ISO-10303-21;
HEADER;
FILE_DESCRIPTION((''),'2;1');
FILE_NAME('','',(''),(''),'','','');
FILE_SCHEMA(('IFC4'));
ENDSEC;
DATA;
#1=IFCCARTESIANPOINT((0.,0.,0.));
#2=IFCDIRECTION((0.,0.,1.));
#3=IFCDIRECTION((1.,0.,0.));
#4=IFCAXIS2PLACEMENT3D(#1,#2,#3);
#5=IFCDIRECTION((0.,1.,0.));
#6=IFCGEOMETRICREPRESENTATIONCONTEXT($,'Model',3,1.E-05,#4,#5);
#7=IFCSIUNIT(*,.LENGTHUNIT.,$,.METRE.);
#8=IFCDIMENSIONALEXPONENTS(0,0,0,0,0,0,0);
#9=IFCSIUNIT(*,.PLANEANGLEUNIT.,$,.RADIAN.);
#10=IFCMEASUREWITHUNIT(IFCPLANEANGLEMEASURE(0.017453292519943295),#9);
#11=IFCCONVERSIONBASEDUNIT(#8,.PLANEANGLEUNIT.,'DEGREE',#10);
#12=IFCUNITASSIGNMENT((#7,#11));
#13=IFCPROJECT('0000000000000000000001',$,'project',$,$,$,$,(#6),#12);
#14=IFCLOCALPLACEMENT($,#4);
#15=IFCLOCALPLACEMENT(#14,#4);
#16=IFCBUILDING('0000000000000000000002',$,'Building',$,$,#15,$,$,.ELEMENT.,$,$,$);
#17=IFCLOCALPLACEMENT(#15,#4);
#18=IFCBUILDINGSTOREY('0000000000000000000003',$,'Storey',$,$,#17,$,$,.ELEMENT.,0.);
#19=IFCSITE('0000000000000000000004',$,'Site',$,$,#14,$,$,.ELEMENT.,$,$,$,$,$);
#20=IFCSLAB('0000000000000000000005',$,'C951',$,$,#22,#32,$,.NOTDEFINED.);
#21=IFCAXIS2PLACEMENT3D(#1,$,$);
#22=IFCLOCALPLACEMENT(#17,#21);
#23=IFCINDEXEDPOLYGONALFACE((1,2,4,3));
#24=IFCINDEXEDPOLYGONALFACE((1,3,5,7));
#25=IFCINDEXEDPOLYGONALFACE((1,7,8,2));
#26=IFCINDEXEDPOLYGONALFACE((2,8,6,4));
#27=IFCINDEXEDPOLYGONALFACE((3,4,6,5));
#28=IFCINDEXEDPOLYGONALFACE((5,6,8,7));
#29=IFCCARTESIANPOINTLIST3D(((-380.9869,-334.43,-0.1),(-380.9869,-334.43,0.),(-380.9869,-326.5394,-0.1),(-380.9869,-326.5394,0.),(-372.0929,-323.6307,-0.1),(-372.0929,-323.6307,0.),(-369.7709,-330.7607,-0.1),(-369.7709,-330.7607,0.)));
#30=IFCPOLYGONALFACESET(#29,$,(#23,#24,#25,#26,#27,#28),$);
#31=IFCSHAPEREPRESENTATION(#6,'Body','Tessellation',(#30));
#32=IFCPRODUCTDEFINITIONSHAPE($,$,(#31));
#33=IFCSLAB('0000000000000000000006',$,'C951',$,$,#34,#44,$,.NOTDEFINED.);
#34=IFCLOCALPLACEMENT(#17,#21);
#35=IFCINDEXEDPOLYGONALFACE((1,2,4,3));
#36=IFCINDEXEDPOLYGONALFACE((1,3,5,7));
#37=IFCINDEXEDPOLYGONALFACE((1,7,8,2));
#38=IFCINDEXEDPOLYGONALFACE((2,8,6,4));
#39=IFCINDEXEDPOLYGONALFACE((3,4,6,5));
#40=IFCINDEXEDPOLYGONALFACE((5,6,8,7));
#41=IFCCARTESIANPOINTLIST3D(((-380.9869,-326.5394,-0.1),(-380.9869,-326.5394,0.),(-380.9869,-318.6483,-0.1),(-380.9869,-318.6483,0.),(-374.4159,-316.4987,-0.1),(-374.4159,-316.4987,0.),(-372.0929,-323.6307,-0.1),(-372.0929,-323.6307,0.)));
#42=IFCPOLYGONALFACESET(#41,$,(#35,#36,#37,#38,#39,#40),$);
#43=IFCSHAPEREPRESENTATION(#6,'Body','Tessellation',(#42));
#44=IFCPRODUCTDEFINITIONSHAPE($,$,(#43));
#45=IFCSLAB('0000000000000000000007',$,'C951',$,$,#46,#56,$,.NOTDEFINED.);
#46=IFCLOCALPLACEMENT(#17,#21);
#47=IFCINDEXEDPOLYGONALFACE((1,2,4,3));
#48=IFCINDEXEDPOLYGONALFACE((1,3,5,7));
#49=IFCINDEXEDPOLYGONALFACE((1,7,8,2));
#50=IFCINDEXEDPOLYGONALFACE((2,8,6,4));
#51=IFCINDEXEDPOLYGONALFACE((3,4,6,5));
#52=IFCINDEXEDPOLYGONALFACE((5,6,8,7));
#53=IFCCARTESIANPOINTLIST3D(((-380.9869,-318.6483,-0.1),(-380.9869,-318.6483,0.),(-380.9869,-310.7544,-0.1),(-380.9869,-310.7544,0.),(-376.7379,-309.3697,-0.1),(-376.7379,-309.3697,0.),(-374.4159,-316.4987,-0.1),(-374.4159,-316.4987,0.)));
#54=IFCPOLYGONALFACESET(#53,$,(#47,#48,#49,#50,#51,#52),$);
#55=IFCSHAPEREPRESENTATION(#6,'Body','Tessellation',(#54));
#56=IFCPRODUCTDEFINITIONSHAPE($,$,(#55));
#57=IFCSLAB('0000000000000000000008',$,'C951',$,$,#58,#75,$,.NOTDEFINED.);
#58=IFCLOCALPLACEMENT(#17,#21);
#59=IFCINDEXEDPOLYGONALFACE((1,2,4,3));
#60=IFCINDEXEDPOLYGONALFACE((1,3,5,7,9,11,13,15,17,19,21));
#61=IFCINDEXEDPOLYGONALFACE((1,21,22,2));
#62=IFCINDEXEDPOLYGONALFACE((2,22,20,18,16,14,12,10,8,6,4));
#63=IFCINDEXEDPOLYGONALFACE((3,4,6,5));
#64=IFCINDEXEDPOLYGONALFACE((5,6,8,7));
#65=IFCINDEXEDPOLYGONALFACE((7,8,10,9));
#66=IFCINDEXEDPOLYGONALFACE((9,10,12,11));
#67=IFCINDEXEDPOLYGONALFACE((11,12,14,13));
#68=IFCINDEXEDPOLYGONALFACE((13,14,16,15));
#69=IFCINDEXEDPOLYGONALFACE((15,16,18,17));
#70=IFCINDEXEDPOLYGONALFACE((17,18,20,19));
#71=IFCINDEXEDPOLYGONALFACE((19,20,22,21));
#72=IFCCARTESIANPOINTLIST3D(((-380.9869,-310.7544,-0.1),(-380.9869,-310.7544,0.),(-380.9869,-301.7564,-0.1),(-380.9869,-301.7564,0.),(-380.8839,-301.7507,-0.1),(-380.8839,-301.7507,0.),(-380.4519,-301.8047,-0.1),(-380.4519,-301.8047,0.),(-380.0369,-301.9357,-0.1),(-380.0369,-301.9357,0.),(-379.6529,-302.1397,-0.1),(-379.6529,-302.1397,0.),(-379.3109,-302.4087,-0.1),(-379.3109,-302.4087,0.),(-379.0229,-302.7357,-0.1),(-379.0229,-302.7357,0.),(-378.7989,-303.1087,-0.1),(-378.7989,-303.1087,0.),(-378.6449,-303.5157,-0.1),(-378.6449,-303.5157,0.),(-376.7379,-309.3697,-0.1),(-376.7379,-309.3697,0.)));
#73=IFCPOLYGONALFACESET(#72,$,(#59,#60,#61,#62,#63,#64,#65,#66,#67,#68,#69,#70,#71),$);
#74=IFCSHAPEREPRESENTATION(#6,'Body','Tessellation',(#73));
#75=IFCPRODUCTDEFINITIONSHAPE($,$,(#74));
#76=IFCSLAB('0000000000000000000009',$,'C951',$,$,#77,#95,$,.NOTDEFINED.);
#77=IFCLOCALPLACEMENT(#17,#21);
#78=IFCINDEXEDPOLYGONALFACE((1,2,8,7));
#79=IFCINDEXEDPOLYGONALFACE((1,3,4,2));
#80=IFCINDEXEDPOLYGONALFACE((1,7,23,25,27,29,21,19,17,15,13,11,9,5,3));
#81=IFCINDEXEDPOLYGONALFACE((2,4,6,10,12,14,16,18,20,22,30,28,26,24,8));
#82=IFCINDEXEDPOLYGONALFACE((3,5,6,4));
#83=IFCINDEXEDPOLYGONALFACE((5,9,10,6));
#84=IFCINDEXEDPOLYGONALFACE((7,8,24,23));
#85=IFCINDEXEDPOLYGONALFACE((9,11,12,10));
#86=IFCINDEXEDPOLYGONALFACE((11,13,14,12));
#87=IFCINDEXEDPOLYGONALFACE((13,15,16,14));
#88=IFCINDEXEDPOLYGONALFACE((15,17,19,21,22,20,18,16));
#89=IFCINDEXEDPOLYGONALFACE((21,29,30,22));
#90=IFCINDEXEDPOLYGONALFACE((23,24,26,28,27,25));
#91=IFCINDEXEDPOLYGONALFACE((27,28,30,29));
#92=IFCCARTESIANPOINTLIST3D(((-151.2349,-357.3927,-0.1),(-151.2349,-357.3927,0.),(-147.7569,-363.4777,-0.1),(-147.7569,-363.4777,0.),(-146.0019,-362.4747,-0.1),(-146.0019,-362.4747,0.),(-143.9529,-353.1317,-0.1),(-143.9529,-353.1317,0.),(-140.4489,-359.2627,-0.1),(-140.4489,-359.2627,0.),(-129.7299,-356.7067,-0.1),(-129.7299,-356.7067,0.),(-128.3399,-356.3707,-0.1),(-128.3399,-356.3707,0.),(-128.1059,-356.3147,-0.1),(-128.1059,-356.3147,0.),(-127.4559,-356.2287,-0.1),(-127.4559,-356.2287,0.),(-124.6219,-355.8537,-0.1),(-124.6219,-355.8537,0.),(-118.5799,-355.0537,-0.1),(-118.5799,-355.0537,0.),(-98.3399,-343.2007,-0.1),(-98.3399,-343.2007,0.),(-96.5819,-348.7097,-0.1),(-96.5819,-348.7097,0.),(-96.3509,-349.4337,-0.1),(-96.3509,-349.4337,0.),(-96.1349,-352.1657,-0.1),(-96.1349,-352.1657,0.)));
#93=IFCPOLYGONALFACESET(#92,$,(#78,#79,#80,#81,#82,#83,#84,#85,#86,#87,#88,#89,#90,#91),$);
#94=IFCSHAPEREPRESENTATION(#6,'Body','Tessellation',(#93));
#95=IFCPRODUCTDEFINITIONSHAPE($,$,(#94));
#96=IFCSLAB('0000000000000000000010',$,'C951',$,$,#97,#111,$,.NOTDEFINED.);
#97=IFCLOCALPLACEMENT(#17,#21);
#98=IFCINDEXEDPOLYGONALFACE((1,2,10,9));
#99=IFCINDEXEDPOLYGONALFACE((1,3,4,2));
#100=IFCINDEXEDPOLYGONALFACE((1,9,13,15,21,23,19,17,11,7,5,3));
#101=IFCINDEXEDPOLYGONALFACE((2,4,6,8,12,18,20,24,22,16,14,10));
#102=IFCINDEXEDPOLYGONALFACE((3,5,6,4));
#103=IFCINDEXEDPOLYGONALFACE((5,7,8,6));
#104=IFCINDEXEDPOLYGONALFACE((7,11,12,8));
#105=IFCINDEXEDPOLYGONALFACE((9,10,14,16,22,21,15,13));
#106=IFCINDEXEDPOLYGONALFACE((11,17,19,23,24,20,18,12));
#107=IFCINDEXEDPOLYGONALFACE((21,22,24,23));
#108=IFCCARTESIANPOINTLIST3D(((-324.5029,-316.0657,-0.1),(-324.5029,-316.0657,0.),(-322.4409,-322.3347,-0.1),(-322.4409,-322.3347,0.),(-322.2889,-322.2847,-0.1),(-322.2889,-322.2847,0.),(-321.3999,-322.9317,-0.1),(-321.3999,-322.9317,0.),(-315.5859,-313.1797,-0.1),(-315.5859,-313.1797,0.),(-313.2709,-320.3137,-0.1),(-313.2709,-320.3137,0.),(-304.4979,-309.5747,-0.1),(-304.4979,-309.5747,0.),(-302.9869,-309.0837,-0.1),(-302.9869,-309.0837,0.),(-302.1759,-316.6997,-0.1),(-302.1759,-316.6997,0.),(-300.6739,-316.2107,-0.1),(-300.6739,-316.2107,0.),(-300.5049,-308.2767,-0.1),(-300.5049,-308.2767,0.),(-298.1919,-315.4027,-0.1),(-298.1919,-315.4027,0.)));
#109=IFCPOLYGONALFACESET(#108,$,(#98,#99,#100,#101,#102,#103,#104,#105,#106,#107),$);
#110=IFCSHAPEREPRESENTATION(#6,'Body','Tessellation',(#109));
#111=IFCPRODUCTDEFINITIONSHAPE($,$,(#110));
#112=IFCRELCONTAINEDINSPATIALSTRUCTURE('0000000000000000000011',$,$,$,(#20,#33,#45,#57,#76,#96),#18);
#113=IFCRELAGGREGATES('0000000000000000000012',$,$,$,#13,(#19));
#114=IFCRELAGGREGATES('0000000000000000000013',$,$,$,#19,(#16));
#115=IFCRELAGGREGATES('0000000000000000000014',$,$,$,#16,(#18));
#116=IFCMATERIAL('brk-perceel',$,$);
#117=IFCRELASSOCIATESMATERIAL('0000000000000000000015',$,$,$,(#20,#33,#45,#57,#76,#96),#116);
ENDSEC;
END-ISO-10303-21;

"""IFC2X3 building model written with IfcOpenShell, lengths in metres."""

from ifc_helpers import new_model, entity, si_unit, converted_unit, direction, frame, origin_with_axes, place, context, project, spatial, polyline, outline, extrude, material, element, save


model = new_model("IFC2X3")

# Units and contexts
model_context = context("Model", 3, precision=1e-05, world=origin_with_axes(), true_north=direction((0.0, 1.0, 0.0)))
ifc_project = project(units=[si_unit("LENGTHUNIT", "METRE"), converted_unit("PLANEANGLEUNIT", "DEGREE", entity("IfcPlaneAngleMeasure", 0.017453292519943295), si_unit("PLANEANGLEUNIT", "RADIAN"), dimensions=[0, 0, 0, 0, 0, 0, 0])], contexts=[model_context])

# Site, building, storey
site_placement = place(None, origin_with_axes())
site = spatial("IfcSite", under=ifc_project, at=site_placement, Name="Site", CompositionType="ELEMENT")
building_placement = place(site_placement, origin_with_axes())
building = spatial("IfcBuilding", under=site, at=building_placement, Name="Building", CompositionType="ELEMENT")
storey_placement = place(building_placement, origin_with_axes())
storey = spatial("IfcBuildingStorey", under=building, at=storey_placement, Name="Storey", CompositionType="ELEMENT", Elevation=0.0)

# Slabs
ifc_material = material(Name="brk-perceel")
slab_1_placement = place(storey_placement, frame((0.0, 0.0, -0.1), z_axis=(0.0, 0.0, 1.0), x_axis=(1.0, 0.0, 0.0)))
element("IfcSlab", 1, at=slab_1_placement, inside=storey, material=ifc_material, Name="C951", PredefinedType="NOTDEFINED", context=model_context, shape_type="SweptSolid", body=[
    extrude(outline(polyline([(-372.0929, -323.6307), (-369.7709, -330.7607), (-380.9869, -334.43), (-380.9869, -326.5394), (-372.0929, -323.6307)])), origin_with_axes(), (0.0, 0.0, 1.0), 0.1),
])
slab_2_placement = place(storey_placement, frame((0.0, 0.0, -0.1), z_axis=(0.0, 0.0, 1.0), x_axis=(1.0, 0.0, 0.0)))
element("IfcSlab", 2, at=slab_2_placement, inside=storey, material=ifc_material, Name="C951", PredefinedType="NOTDEFINED", context=model_context, shape_type="SweptSolid", body=[
    extrude(outline(polyline([(-374.4159, -316.4987), (-372.0929, -323.6307), (-380.9869, -326.5394), (-380.9869, -318.6483), (-374.4159, -316.4987)])), origin_with_axes(), (0.0, 0.0, 1.0), 0.1),
])
slab_3_placement = place(storey_placement, frame((0.0, 0.0, -0.1), z_axis=(0.0, 0.0, 1.0), x_axis=(1.0, 0.0, 0.0)))
element("IfcSlab", 3, at=slab_3_placement, inside=storey, material=ifc_material, Name="C951", PredefinedType="NOTDEFINED", context=model_context, shape_type="SweptSolid", body=[
    extrude(outline(polyline([(-376.7379, -309.3697), (-374.4159, -316.4987), (-380.9869, -318.6483), (-380.9869, -310.7544), (-376.7379, -309.3697)])), origin_with_axes(), (0.0, 0.0, 1.0), 0.1),
])
slab_4_placement = place(storey_placement, frame((0.0, 0.0, -0.1), z_axis=(0.0, 0.0, 1.0), x_axis=(1.0, 0.0, 0.0)))
element("IfcSlab", 4, at=slab_4_placement, inside=storey, material=ifc_material, Name="C951", PredefinedType="NOTDEFINED", context=model_context, shape_type="SweptSolid", body=[
    extrude(outline(polyline([(-380.8839, -301.7507), (-380.4519, -301.8047), (-380.0369, -301.9357), (-379.6529, -302.1397), (-379.3109, -302.4087), (-379.0229, -302.7357), (-378.7989, -303.1087), (-378.6449, -303.5157), (-376.7379, -309.3697), (-380.9869, -310.7544), (-380.9869, -301.7564), (-380.8839, -301.7507)])), origin_with_axes(), (0.0, 0.0, 1.0), 0.1),
])
slab_5_placement = place(storey_placement, frame((0.0, 0.0, -0.1), z_axis=(0.0, 0.0, 1.0), x_axis=(1.0, 0.0, 0.0)))
element("IfcSlab", 5, at=slab_5_placement, inside=storey, material=ifc_material, Name="C951", PredefinedType="NOTDEFINED", context=model_context, shape_type="SweptSolid", body=[
    extrude(outline(polyline([(-127.4559, -356.2287), (-128.1059, -356.3147), (-128.3399, -356.3707), (-129.7299, -356.7067), (-140.4489, -359.2627), (-146.0019, -362.4747), (-147.7569, -363.4777), (-151.2349, -357.3927), (-143.9529, -353.1317), (-98.3399, -343.2007), (-96.5819, -348.7097), (-96.3509, -349.4337), (-96.1349, -352.1657), (-118.5799, -355.0537), (-124.6219, -355.8537), (-127.4559, -356.2287)])), origin_with_axes(), (0.0, 0.0, 1.0), 0.1),
])
slab_6_placement = place(storey_placement, frame((0.0, 0.0, -0.1), z_axis=(0.0, 0.0, 1.0), x_axis=(1.0, 0.0, 0.0)))
element("IfcSlab", 6, at=slab_6_placement, inside=storey, material=ifc_material, Name="C951", PredefinedType="NOTDEFINED", context=model_context, shape_type="SweptSolid", body=[
    extrude(outline(polyline([(-324.5029, -316.0657), (-315.5859, -313.1797), (-304.4979, -309.5747), (-302.9869, -309.0837), (-300.5049, -308.2767), (-298.1919, -315.4027), (-300.6739, -316.2107), (-302.1759, -316.6997), (-313.2709, -320.3137), (-321.3999, -322.9317), (-322.2889, -322.2847), (-322.4409, -322.3347), (-324.5029, -316.0657)])), origin_with_axes(), (0.0, 0.0, 1.0), 0.1),
])

save(model, "model.ifc")
